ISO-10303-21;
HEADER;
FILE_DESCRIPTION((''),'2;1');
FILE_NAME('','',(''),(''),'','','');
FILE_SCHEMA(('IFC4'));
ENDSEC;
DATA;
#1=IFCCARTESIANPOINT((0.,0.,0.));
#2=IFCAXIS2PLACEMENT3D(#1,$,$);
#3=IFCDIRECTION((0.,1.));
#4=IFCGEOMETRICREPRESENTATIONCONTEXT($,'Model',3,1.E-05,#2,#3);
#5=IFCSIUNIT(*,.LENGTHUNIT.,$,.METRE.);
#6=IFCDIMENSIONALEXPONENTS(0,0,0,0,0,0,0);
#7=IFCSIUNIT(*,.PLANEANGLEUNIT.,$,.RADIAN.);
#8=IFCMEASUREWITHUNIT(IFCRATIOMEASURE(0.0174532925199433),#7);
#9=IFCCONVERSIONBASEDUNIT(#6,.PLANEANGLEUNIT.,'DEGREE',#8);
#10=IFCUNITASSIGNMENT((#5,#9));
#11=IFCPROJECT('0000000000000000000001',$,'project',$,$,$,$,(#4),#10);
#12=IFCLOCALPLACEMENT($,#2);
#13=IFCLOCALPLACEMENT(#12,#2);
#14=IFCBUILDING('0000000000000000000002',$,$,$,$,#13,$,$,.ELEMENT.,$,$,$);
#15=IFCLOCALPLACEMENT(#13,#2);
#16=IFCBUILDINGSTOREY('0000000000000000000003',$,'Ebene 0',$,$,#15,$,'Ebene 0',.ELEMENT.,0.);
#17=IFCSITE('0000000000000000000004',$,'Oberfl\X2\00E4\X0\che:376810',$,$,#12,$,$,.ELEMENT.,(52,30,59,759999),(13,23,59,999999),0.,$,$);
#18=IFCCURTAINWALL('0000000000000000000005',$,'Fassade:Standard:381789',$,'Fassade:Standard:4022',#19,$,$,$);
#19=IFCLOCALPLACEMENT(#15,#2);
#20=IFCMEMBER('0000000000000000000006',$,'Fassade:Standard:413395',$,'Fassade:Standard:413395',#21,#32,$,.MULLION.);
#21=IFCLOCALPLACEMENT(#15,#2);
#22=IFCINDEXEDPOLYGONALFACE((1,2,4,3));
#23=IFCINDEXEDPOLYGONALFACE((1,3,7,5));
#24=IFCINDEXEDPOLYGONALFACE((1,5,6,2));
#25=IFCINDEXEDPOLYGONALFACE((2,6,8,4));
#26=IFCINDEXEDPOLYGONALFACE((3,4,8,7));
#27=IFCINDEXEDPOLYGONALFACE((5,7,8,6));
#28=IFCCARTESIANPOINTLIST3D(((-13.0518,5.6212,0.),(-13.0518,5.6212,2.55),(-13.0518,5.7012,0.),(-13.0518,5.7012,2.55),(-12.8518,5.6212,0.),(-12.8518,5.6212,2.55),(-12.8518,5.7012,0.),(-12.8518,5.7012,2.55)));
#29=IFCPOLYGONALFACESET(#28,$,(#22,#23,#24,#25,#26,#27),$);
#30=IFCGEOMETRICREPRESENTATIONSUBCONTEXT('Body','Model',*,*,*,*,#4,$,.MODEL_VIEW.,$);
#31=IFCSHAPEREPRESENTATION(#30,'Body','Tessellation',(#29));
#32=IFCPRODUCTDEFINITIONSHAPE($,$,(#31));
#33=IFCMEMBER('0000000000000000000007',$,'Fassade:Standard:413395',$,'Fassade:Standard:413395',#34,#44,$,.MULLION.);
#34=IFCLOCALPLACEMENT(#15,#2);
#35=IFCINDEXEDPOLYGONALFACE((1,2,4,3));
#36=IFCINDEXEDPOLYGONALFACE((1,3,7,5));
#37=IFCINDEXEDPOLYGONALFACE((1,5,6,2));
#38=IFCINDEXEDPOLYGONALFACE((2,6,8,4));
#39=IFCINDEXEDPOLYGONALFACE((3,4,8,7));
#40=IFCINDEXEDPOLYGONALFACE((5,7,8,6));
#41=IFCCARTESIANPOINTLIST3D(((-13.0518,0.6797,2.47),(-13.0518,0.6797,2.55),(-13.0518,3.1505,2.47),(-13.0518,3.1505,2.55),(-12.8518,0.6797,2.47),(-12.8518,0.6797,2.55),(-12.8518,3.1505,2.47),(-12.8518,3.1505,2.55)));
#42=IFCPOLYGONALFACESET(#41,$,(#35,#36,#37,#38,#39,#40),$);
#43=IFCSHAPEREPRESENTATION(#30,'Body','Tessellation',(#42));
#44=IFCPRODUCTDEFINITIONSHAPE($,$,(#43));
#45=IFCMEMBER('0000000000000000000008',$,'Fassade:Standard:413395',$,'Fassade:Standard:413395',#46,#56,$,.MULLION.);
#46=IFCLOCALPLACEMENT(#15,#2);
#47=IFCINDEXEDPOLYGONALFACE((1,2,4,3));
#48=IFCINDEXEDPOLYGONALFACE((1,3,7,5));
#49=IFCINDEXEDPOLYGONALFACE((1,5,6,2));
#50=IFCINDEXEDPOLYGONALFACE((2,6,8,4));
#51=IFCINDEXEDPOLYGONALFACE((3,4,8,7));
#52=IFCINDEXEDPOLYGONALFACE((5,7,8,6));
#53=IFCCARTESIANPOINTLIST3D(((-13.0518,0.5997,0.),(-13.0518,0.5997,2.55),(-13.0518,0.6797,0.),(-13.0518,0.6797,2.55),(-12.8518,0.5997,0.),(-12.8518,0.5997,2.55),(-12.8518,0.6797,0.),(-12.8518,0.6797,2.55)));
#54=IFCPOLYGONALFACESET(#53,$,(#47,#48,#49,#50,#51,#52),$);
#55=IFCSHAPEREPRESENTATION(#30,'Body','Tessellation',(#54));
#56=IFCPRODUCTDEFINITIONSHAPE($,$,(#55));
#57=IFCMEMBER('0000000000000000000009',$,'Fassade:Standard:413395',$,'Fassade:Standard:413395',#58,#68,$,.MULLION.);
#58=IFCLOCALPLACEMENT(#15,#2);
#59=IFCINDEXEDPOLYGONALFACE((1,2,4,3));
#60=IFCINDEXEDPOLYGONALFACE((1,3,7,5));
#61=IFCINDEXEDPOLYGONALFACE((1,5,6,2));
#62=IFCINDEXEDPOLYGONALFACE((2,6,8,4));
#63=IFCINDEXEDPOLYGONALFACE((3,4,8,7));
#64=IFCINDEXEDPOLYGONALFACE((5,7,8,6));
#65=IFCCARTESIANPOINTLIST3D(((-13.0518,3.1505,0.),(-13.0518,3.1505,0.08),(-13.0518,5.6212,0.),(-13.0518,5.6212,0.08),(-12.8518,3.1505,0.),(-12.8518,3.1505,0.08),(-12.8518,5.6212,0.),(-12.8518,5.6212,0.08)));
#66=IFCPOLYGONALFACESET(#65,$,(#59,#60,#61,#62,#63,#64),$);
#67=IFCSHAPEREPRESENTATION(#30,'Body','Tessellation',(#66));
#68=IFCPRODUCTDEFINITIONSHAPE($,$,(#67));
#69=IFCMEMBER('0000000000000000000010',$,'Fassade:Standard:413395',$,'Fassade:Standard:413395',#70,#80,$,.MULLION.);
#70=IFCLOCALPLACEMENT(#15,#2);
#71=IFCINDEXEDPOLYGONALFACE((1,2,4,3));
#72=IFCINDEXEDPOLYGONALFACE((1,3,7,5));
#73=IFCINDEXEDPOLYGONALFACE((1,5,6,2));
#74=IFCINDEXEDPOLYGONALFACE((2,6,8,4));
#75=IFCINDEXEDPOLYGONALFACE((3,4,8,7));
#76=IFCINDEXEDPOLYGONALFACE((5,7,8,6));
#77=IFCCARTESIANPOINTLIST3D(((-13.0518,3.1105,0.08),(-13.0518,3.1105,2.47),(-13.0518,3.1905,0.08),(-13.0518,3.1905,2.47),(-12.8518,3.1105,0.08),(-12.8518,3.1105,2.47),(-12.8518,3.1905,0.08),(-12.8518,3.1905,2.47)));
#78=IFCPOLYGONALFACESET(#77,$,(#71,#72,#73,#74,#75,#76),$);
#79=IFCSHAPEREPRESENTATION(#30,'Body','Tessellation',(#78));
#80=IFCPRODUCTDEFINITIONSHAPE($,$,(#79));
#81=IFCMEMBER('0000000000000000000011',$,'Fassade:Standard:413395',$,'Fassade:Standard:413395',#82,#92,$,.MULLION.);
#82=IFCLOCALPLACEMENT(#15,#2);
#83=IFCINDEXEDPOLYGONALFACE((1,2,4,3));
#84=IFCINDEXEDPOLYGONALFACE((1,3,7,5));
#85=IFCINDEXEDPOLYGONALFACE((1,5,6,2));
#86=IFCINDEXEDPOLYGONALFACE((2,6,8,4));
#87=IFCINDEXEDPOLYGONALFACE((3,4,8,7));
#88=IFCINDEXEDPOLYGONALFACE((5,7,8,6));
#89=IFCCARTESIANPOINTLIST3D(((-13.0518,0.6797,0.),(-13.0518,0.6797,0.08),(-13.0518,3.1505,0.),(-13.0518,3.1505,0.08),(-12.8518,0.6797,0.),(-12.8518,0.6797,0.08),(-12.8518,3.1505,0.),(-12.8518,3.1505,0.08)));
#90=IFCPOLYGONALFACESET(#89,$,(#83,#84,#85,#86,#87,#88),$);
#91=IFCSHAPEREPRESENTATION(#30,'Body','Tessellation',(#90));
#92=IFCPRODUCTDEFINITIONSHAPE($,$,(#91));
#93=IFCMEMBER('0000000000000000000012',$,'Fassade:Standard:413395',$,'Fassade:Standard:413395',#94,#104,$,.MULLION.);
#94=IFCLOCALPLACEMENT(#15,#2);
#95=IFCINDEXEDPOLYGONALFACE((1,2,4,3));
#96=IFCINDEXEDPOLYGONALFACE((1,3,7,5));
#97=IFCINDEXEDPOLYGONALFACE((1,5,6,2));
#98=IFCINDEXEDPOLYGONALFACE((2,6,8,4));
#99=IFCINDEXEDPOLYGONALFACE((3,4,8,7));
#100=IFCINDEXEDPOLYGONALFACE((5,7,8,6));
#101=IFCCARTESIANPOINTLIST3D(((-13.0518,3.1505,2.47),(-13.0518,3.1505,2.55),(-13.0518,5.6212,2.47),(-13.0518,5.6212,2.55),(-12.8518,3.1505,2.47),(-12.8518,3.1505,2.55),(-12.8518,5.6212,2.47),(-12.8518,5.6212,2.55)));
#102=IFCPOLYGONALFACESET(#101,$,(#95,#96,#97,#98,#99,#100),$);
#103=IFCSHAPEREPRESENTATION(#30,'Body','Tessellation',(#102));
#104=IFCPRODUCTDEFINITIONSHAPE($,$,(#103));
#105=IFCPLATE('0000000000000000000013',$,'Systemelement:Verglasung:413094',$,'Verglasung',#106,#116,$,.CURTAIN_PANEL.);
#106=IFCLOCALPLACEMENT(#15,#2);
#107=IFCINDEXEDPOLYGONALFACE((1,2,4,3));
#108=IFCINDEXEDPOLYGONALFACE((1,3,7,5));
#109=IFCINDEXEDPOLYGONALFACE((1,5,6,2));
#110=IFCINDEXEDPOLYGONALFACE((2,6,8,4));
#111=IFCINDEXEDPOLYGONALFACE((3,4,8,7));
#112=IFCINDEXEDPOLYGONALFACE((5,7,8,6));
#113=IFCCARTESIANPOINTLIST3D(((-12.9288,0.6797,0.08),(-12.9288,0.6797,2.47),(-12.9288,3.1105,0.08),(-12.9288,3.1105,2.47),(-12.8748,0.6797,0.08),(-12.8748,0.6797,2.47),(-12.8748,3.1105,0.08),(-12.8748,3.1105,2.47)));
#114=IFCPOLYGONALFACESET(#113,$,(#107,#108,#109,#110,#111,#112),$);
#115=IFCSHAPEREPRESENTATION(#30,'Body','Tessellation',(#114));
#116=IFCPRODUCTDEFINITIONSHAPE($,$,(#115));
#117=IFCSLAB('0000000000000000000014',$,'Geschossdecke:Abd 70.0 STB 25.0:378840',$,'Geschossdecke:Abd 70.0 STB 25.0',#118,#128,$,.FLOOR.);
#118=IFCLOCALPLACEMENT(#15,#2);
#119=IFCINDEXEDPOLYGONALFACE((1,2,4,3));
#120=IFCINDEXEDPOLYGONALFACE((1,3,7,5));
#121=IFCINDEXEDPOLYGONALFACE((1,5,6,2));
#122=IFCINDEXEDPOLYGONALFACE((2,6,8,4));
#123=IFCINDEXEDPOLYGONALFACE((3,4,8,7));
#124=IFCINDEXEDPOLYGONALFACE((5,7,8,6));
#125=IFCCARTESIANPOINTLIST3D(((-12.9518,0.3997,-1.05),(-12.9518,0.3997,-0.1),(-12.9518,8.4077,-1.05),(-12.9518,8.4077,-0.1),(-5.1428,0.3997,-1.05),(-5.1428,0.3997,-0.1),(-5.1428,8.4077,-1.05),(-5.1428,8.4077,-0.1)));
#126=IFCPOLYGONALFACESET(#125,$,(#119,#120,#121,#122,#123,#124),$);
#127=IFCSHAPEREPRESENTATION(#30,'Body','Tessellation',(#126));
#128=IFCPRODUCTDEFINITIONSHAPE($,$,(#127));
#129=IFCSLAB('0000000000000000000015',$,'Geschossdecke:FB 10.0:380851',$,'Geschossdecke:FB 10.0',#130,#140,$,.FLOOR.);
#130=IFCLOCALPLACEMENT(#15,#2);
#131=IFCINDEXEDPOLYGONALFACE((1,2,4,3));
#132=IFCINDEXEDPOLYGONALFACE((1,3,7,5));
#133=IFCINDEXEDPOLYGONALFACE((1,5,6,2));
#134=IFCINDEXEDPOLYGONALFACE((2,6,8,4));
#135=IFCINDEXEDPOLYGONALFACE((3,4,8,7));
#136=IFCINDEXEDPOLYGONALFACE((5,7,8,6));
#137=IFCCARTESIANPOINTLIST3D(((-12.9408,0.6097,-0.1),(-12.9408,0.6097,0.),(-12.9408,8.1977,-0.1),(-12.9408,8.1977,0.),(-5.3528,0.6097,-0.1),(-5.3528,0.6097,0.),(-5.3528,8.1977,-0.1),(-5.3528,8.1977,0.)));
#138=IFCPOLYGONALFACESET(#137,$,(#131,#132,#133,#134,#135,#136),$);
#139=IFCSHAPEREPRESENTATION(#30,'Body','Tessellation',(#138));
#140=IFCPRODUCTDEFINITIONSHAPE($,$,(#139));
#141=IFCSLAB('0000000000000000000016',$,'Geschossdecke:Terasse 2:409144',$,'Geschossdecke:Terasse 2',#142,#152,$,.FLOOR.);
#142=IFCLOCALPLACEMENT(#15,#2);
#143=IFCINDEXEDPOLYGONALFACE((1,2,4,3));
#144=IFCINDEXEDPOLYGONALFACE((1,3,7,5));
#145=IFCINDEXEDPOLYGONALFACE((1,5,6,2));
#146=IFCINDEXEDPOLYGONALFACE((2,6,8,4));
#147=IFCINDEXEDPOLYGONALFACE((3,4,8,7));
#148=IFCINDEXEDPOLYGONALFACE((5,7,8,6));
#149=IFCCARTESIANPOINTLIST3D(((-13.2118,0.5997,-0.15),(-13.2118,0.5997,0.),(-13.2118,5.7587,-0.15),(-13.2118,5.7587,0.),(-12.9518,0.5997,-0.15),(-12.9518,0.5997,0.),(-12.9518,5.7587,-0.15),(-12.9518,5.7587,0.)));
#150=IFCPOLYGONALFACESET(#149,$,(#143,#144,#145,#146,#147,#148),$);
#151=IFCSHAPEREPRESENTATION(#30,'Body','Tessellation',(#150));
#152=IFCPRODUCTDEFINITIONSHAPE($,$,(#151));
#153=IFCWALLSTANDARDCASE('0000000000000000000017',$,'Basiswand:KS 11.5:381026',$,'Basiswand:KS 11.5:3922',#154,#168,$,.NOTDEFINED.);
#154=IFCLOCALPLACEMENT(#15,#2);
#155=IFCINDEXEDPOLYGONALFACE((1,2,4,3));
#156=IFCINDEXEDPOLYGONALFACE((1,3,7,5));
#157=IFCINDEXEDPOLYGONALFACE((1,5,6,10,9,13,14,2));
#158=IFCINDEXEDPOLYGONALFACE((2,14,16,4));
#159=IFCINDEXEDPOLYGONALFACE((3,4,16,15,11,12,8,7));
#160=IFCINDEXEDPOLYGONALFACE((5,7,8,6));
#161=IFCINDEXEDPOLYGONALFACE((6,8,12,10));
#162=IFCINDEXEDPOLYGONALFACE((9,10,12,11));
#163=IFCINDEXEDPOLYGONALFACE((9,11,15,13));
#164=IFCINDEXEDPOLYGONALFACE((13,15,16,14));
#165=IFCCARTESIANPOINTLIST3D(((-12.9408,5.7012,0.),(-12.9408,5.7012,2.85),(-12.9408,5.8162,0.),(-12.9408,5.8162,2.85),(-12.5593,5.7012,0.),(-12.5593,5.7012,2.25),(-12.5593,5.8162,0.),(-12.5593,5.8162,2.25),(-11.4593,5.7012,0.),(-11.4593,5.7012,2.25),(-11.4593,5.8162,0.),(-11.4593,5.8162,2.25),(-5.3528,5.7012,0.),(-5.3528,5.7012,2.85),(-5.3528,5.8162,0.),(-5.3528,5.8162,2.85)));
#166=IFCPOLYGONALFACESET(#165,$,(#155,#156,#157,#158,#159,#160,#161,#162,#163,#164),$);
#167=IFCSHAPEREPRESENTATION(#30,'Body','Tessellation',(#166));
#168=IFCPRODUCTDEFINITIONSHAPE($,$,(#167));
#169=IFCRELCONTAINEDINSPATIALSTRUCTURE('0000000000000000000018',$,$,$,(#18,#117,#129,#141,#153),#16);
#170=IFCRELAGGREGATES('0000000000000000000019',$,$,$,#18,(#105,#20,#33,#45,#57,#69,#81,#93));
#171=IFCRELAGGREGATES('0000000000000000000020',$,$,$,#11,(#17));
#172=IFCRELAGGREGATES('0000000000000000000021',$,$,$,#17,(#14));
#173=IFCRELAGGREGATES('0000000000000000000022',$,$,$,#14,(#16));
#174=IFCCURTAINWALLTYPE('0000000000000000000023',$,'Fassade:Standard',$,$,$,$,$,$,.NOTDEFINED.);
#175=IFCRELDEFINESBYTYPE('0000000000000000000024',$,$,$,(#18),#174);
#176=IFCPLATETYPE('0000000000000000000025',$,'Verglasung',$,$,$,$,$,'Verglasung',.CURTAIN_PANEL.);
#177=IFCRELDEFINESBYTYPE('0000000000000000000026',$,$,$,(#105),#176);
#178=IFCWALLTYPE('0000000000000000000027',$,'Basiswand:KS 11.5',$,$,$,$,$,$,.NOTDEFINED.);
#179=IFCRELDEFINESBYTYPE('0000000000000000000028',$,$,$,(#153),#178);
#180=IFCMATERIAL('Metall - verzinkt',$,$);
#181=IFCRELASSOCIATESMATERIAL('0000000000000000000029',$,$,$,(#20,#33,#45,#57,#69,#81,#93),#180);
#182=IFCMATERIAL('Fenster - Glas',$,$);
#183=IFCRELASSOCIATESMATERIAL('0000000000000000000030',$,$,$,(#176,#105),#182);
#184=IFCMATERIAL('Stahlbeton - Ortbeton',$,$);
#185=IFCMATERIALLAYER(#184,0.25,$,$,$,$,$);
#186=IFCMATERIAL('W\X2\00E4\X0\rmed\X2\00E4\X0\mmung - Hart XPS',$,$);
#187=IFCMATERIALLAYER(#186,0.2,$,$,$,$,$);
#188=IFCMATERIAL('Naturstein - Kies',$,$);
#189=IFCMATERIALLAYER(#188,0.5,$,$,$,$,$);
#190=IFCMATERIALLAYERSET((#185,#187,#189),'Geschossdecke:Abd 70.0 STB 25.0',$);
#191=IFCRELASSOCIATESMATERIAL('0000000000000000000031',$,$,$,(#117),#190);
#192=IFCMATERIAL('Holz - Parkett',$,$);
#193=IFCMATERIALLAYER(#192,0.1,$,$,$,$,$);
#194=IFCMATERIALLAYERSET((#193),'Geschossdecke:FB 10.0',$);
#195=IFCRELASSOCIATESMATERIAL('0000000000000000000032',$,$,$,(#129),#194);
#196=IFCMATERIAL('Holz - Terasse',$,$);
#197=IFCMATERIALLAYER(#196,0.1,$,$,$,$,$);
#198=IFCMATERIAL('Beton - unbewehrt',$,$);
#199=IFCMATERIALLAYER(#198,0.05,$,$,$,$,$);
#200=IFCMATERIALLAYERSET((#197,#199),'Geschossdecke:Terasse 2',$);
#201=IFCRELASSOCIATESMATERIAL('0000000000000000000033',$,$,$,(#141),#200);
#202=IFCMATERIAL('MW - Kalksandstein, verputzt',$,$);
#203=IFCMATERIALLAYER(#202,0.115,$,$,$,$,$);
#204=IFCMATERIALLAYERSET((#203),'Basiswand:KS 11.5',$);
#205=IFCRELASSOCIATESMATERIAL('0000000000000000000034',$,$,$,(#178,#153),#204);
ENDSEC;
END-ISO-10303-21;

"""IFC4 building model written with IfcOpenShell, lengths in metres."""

from ifc_helpers import new_model, entity, si_unit, converted_unit, direction, frame, frame_2d, origin, origin_2d_with_axis, place, context, subcontext, project, spatial, polyline, rectangle, extrude, clip, bounded_halfspace, source, transform, mapped, material, layer, layer_set, layer_usage, type_object, type_shapes, element, aggregate, save


model = new_model("IFC4")

# Units and contexts
model_context = context("Model", 3, precision=1e-05, world=origin(), true_north=direction((0.0, 1.0)))
body_context = subcontext(model_context, "Body", "Model", "MODEL_VIEW")
ifc_project = project(units=[si_unit("LENGTHUNIT", "METRE"), converted_unit("PLANEANGLEUNIT", "DEGREE", entity("IfcRatioMeasure", 0.0174532925199433), si_unit("PLANEANGLEUNIT", "RADIAN"), dimensions=[0, 0, 0, 0, 0, 0, 0])], contexts=[model_context])

# Site, building, storey
site_placement = place(None, origin())
site = spatial("IfcSite", under=ifc_project, at=site_placement, Name="Oberfläche:376810", CompositionType="ELEMENT", RefLatitude=(52, 30, 59, 759999), RefLongitude=(13, 23, 59, 999999), RefElevation=0.0)
building_placement = place(site_placement, origin())
building = spatial("IfcBuilding", under=site, at=building_placement, CompositionType="ELEMENT")
storey_placement = place(building_placement, origin())
storey = spatial("IfcBuildingStorey", under=building, at=storey_placement, Name="Ebene 0", LongName="Ebene 0", CompositionType="ELEMENT", Elevation=0.0)

# Curtain wall, members, plate
curtain_wall_type = type_object("IfcCurtainWallType", Name="Fassade:Standard", PredefinedType="NOTDEFINED")
curtain_wall_placement = place(storey_placement, origin())
curtain_wall = element("IfcCurtainWall", 1, at=curtain_wall_placement, inside=storey, type_object=curtain_wall_type, Name="Fassade:Standard:381789", ObjectType="Fassade:Standard:4022")
ifc_material_1 = material(Name="Metall - verzinkt")
member_1_placement = place(curtain_wall_placement, origin())
member_1 = element("IfcMember", 2, at=member_1_placement, material=ifc_material_1, Name="Fassade:Standard:413395", ObjectType="Fassade:Standard:413395", PredefinedType="MULLION", context=body_context, shape_type="SweptSolid", body=[
    extrude(rectangle(XDim=0.2, YDim=0.08, at=frame_2d((0.0, 0.0), x_axis=(1.0, 0.0))), frame((-12.9518, 5.6612, 2.55), z_axis=(0.0, 0.0, -1.0), x_axis=(-1.0, 0.0, 0.0)), (0.0, 0.0, 1.0), 2.55),
])
member_2_placement = place(curtain_wall_placement, origin())
member_2 = element("IfcMember", 3, at=member_2_placement, material=ifc_material_1, Name="Fassade:Standard:413395", ObjectType="Fassade:Standard:413395", PredefinedType="MULLION", context=body_context, shape_type="SweptSolid", body=[
    extrude(rectangle(XDim=0.08, YDim=0.2, at=origin_2d_with_axis()), frame((-12.9518, 0.6797, 2.51), z_axis=(0.0, 1.0, 0.0), x_axis=(0.0, 0.0, -1.0)), (0.0, 0.0, 1.0), 2.4708),
])
member_3_placement = place(curtain_wall_placement, origin())
member_3 = element("IfcMember", 4, at=member_3_placement, material=ifc_material_1, Name="Fassade:Standard:413395", ObjectType="Fassade:Standard:413395", PredefinedType="MULLION", context=body_context, shape_type="SweptSolid", body=[
    extrude(rectangle(XDim=0.2, YDim=0.08, at=frame_2d((0.0, 0.0), x_axis=(1.0, 0.0))), frame((-12.9518, 0.6397, 0.0), z_axis=(0.0, 0.0, 1.0), x_axis=(-1.0, 0.0, 0.0)), (0.0, 0.0, 1.0), 2.55),
])
member_4_placement = place(curtain_wall_placement, origin())
member_4 = element("IfcMember", 5, at=member_4_placement, material=ifc_material_1, Name="Fassade:Standard:413395", ObjectType="Fassade:Standard:413395", PredefinedType="MULLION", context=body_context, shape_type="SweptSolid", body=[
    extrude(rectangle(XDim=0.08, YDim=0.2, at=origin_2d_with_axis()), frame((-12.9518, 5.6212, 0.04), z_axis=(0.0, -1.0, 0.0), x_axis=(0.0, 0.0, -1.0)), (0.0, 0.0, 1.0), 2.4707),
])
member_5_placement = place(curtain_wall_placement, origin())
member_5 = element("IfcMember", 6, at=member_5_placement, material=ifc_material_1, Name="Fassade:Standard:413395", ObjectType="Fassade:Standard:413395", PredefinedType="MULLION", context=body_context, shape_type="SweptSolid", body=[
    extrude(rectangle(XDim=0.2, YDim=0.08, at=frame_2d((0.0, 0.0), x_axis=(1.0, 0.0))), frame((-12.9518, 3.1505, 0.08), z_axis=(0.0, 0.0, 1.0), x_axis=(-1.0, 0.0, 0.0)), (0.0, 0.0, 1.0), 2.39),
])
member_6_placement = place(curtain_wall_placement, origin())
member_6 = element("IfcMember", 7, at=member_6_placement, material=ifc_material_1, Name="Fassade:Standard:413395", ObjectType="Fassade:Standard:413395", PredefinedType="MULLION", context=body_context, shape_type="SweptSolid", body=[
    extrude(rectangle(XDim=0.08, YDim=0.2, at=origin_2d_with_axis()), frame((-12.9518, 3.1505, 0.04), z_axis=(0.0, -1.0, 0.0), x_axis=(0.0, 0.0, -1.0)), (0.0, 0.0, 1.0), 2.4708),
])
member_7_placement = place(curtain_wall_placement, origin())
member_7 = element("IfcMember", 8, at=member_7_placement, material=ifc_material_1, Name="Fassade:Standard:413395", ObjectType="Fassade:Standard:413395", PredefinedType="MULLION", context=body_context, shape_type="SweptSolid", body=[
    extrude(rectangle(XDim=0.08, YDim=0.2, at=origin_2d_with_axis()), frame((-12.9518, 3.1505, 2.51), z_axis=(0.0, 1.0, 0.0), x_axis=(0.0, 0.0, -1.0)), (0.0, 0.0, 1.0), 2.4707),
])
ifc_material_2 = material(Name="Fenster - Glas")
plate_type_1 = type_object("IfcPlateType", Name="Verglasung", ElementType="Verglasung", PredefinedType="CURTAIN_PANEL", material=ifc_material_2)
shared_shape_1 = source(origin(), body_context, "Body", "SweptSolid", [
    extrude(rectangle(XDim=0.054, YDim=2.4308, at=frame_2d((0.0, 0.0), x_axis=(1.0, 0.0))), frame((1.2154, 0.027, 0.0), z_axis=(0.0, 0.0, 1.0), x_axis=(0.0, 1.0, 0.0)), (0.0, 0.0, 1.0), 2.39),
])
type_shapes(plate_type_1, [shared_shape_1])
plate_1_placement = place(curtain_wall_placement, frame((-12.9288, 3.1105, 0.08), z_axis=(0.0, 0.0, 1.0), x_axis=(0.0, -1.0, 0.0)))
plate_1 = element("IfcPlate", 9, at=plate_1_placement, type_object=plate_type_1, material=ifc_material_2, Name="Systemelement:Verglasung:413094", ObjectType="Verglasung", PredefinedType="CURTAIN_PANEL", context=body_context, shape_type="MappedRepresentation", body=[
    mapped(shared_shape_1, transform((0.0, 0.0, 0.0), scale=1.0)),
])
aggregate(curtain_wall, [plate_1, member_1, member_2, member_3, member_4, member_5, member_6, member_7])

# Slabs
ifc_material_3 = material(Name="Stahlbeton - Ortbeton")
ifc_layer_1 = layer(ifc_material_3, 0.25)
ifc_material_4 = material(Name="Wärmedämmung - Hart XPS")
ifc_layer_2 = layer(ifc_material_4, 0.2)
ifc_material_5 = material(Name="Naturstein - Kies")
ifc_layer_3 = layer(ifc_material_5, 0.5)
ifc_layer_set_1 = layer_set([ifc_layer_1, ifc_layer_2, ifc_layer_3], Name="Geschossdecke:Abd 70.0 STB 25.0")
ifc_layer_usage_1 = layer_usage(ifc_layer_set_1, "AXIS3", "POSITIVE", 0.0)
slab_1_placement = place(storey_placement, origin())
element("IfcSlab", 10, at=slab_1_placement, inside=storey, material=ifc_layer_usage_1, Name="Geschossdecke:Abd 70.0 STB 25.0:378840", ObjectType="Geschossdecke:Abd 70.0 STB 25.0", PredefinedType="FLOOR", context=body_context, shape_type="SweptSolid", body=[
    extrude(rectangle(XDim=7.809, YDim=8.008, at=origin_2d_with_axis()), frame((-9.0473, 4.4037, -0.1), z_axis=(0.0, 0.0, -1.0), x_axis=(1.0, 0.0, 0.0)), (0.0, 0.0, 1.0), 0.95),
])
ifc_material_6 = material(Name="Holz - Parkett")
ifc_layer_4 = layer(ifc_material_6, 0.1)
ifc_layer_set_2 = layer_set([ifc_layer_4], Name="Geschossdecke:FB 10.0")
ifc_layer_usage_2 = layer_usage(ifc_layer_set_2, "AXIS3", "POSITIVE", 0.0)
slab_2_placement = place(storey_placement, origin())
element("IfcSlab", 11, at=slab_2_placement, inside=storey, material=ifc_layer_usage_2, Name="Geschossdecke:FB 10.0:380851", ObjectType="Geschossdecke:FB 10.0", PredefinedType="FLOOR", context=body_context, shape_type="SweptSolid", body=[
    extrude(rectangle(XDim=7.588, YDim=7.588, at=frame_2d((0.0, 0.0), x_axis=(1.0, 0.0))), frame((-9.1468, 4.4037, 0.0), z_axis=(0.0, 0.0, -1.0), x_axis=(1.0, 0.0, 0.0)), (0.0, 0.0, 1.0), 0.1),
])
ifc_material_7 = material(Name="Holz - Terasse")
ifc_material_8 = material(Name="Beton - unbewehrt")
ifc_layer_5 = layer(ifc_material_7, 0.1)
ifc_layer_6 = layer(ifc_material_8, 0.05)
ifc_layer_set_3 = layer_set([ifc_layer_5, ifc_layer_6], Name="Geschossdecke:Terasse 2")
ifc_layer_usage_3 = layer_usage(ifc_layer_set_3, "AXIS3", "POSITIVE", 0.0)
slab_3_placement = place(storey_placement, origin())
element("IfcSlab", 12, at=slab_3_placement, inside=storey, material=ifc_layer_usage_3, Name="Geschossdecke:Terasse 2:409144", ObjectType="Geschossdecke:Terasse 2", PredefinedType="FLOOR", context=body_context, shape_type="SweptSolid", body=[
    extrude(rectangle(XDim=5.159, YDim=0.26, at=frame_2d((0.0, 0.0), x_axis=(1.0, 0.0))), frame((-13.0818, 3.1792, 0.0), z_axis=(0.0, 0.0, -1.0), x_axis=(0.0, 1.0, 0.0)), (0.0, 0.0, 1.0), 0.15),
])

# Wall, opening
ifc_material_9 = material(Name="MW - Kalksandstein, verputzt")
ifc_layer_7 = layer(ifc_material_9, 0.115)
ifc_layer_set_4 = layer_set([ifc_layer_7], Name="Basiswand:KS 11.5")
ifc_layer_usage_4 = layer_usage(ifc_layer_set_4, "AXIS2", "NEGATIVE", 0.0575)
wall_type_1 = type_object("IfcWallType", Name="Basiswand:KS 11.5", PredefinedType="NOTDEFINED", material=ifc_layer_set_4)
wall_1_placement = place(storey_placement, frame((-12.9408, 5.7587, 0.0)))
wall_1 = element("IfcWallStandardCase", 13, at=wall_1_placement, inside=storey, type_object=wall_type_1, material=ifc_layer_usage_4, Name="Basiswand:KS 11.5:381026", ObjectType="Basiswand:KS 11.5:3922", PredefinedType="NOTDEFINED", context=body_context, shape_type="Clipping", body=[
    clip(extrude(rectangle(XDim=7.588, YDim=0.115, at=frame_2d((3.794, 0.0), x_axis=(-1.0, 0.0))), origin(), (0.0, 0.0, 1.0), 2.85), bounded_halfspace(frame((7.588, 0.0575, 2.85), z_axis=(0.0, 0.0, -1.0), x_axis=(1.0, 0.0, 0.0)), True, frame((7.588, 0.0575, 2.85)), polyline([(0.0, 0.0), (-2.6215, 0.0), (-2.7365, 0.0), (-7.588, 0.0), (-7.588, -0.115), (-7.579, -0.115), (-7.489, -0.115), (-2.7365, -0.115), (-2.6215, -0.115), (0.0, -0.115), (0.0, 0.0)]))),
])
opening_1_placement = place(wall_1_placement, frame((1.4815, 0.0575, 0.0)))
element("IfcOpeningElement", 14, at=opening_1_placement, cuts=wall_1, ObjectType="Opening", PredefinedType="OPENING", context=body_context, shape_type="SweptSolid", body=[
    extrude(rectangle(XDim=2.25, YDim=1.1, at=frame_2d((1.125, 0.55), x_axis=(1.0, 0.0))), frame((0.0, 0.0, 0.0), z_axis=(0.0, -1.0, 0.0), x_axis=(0.0, 0.0, 1.0)), (0.0, 0.0, 1.0), 0.115),
])

save(model, "model.ifc")
